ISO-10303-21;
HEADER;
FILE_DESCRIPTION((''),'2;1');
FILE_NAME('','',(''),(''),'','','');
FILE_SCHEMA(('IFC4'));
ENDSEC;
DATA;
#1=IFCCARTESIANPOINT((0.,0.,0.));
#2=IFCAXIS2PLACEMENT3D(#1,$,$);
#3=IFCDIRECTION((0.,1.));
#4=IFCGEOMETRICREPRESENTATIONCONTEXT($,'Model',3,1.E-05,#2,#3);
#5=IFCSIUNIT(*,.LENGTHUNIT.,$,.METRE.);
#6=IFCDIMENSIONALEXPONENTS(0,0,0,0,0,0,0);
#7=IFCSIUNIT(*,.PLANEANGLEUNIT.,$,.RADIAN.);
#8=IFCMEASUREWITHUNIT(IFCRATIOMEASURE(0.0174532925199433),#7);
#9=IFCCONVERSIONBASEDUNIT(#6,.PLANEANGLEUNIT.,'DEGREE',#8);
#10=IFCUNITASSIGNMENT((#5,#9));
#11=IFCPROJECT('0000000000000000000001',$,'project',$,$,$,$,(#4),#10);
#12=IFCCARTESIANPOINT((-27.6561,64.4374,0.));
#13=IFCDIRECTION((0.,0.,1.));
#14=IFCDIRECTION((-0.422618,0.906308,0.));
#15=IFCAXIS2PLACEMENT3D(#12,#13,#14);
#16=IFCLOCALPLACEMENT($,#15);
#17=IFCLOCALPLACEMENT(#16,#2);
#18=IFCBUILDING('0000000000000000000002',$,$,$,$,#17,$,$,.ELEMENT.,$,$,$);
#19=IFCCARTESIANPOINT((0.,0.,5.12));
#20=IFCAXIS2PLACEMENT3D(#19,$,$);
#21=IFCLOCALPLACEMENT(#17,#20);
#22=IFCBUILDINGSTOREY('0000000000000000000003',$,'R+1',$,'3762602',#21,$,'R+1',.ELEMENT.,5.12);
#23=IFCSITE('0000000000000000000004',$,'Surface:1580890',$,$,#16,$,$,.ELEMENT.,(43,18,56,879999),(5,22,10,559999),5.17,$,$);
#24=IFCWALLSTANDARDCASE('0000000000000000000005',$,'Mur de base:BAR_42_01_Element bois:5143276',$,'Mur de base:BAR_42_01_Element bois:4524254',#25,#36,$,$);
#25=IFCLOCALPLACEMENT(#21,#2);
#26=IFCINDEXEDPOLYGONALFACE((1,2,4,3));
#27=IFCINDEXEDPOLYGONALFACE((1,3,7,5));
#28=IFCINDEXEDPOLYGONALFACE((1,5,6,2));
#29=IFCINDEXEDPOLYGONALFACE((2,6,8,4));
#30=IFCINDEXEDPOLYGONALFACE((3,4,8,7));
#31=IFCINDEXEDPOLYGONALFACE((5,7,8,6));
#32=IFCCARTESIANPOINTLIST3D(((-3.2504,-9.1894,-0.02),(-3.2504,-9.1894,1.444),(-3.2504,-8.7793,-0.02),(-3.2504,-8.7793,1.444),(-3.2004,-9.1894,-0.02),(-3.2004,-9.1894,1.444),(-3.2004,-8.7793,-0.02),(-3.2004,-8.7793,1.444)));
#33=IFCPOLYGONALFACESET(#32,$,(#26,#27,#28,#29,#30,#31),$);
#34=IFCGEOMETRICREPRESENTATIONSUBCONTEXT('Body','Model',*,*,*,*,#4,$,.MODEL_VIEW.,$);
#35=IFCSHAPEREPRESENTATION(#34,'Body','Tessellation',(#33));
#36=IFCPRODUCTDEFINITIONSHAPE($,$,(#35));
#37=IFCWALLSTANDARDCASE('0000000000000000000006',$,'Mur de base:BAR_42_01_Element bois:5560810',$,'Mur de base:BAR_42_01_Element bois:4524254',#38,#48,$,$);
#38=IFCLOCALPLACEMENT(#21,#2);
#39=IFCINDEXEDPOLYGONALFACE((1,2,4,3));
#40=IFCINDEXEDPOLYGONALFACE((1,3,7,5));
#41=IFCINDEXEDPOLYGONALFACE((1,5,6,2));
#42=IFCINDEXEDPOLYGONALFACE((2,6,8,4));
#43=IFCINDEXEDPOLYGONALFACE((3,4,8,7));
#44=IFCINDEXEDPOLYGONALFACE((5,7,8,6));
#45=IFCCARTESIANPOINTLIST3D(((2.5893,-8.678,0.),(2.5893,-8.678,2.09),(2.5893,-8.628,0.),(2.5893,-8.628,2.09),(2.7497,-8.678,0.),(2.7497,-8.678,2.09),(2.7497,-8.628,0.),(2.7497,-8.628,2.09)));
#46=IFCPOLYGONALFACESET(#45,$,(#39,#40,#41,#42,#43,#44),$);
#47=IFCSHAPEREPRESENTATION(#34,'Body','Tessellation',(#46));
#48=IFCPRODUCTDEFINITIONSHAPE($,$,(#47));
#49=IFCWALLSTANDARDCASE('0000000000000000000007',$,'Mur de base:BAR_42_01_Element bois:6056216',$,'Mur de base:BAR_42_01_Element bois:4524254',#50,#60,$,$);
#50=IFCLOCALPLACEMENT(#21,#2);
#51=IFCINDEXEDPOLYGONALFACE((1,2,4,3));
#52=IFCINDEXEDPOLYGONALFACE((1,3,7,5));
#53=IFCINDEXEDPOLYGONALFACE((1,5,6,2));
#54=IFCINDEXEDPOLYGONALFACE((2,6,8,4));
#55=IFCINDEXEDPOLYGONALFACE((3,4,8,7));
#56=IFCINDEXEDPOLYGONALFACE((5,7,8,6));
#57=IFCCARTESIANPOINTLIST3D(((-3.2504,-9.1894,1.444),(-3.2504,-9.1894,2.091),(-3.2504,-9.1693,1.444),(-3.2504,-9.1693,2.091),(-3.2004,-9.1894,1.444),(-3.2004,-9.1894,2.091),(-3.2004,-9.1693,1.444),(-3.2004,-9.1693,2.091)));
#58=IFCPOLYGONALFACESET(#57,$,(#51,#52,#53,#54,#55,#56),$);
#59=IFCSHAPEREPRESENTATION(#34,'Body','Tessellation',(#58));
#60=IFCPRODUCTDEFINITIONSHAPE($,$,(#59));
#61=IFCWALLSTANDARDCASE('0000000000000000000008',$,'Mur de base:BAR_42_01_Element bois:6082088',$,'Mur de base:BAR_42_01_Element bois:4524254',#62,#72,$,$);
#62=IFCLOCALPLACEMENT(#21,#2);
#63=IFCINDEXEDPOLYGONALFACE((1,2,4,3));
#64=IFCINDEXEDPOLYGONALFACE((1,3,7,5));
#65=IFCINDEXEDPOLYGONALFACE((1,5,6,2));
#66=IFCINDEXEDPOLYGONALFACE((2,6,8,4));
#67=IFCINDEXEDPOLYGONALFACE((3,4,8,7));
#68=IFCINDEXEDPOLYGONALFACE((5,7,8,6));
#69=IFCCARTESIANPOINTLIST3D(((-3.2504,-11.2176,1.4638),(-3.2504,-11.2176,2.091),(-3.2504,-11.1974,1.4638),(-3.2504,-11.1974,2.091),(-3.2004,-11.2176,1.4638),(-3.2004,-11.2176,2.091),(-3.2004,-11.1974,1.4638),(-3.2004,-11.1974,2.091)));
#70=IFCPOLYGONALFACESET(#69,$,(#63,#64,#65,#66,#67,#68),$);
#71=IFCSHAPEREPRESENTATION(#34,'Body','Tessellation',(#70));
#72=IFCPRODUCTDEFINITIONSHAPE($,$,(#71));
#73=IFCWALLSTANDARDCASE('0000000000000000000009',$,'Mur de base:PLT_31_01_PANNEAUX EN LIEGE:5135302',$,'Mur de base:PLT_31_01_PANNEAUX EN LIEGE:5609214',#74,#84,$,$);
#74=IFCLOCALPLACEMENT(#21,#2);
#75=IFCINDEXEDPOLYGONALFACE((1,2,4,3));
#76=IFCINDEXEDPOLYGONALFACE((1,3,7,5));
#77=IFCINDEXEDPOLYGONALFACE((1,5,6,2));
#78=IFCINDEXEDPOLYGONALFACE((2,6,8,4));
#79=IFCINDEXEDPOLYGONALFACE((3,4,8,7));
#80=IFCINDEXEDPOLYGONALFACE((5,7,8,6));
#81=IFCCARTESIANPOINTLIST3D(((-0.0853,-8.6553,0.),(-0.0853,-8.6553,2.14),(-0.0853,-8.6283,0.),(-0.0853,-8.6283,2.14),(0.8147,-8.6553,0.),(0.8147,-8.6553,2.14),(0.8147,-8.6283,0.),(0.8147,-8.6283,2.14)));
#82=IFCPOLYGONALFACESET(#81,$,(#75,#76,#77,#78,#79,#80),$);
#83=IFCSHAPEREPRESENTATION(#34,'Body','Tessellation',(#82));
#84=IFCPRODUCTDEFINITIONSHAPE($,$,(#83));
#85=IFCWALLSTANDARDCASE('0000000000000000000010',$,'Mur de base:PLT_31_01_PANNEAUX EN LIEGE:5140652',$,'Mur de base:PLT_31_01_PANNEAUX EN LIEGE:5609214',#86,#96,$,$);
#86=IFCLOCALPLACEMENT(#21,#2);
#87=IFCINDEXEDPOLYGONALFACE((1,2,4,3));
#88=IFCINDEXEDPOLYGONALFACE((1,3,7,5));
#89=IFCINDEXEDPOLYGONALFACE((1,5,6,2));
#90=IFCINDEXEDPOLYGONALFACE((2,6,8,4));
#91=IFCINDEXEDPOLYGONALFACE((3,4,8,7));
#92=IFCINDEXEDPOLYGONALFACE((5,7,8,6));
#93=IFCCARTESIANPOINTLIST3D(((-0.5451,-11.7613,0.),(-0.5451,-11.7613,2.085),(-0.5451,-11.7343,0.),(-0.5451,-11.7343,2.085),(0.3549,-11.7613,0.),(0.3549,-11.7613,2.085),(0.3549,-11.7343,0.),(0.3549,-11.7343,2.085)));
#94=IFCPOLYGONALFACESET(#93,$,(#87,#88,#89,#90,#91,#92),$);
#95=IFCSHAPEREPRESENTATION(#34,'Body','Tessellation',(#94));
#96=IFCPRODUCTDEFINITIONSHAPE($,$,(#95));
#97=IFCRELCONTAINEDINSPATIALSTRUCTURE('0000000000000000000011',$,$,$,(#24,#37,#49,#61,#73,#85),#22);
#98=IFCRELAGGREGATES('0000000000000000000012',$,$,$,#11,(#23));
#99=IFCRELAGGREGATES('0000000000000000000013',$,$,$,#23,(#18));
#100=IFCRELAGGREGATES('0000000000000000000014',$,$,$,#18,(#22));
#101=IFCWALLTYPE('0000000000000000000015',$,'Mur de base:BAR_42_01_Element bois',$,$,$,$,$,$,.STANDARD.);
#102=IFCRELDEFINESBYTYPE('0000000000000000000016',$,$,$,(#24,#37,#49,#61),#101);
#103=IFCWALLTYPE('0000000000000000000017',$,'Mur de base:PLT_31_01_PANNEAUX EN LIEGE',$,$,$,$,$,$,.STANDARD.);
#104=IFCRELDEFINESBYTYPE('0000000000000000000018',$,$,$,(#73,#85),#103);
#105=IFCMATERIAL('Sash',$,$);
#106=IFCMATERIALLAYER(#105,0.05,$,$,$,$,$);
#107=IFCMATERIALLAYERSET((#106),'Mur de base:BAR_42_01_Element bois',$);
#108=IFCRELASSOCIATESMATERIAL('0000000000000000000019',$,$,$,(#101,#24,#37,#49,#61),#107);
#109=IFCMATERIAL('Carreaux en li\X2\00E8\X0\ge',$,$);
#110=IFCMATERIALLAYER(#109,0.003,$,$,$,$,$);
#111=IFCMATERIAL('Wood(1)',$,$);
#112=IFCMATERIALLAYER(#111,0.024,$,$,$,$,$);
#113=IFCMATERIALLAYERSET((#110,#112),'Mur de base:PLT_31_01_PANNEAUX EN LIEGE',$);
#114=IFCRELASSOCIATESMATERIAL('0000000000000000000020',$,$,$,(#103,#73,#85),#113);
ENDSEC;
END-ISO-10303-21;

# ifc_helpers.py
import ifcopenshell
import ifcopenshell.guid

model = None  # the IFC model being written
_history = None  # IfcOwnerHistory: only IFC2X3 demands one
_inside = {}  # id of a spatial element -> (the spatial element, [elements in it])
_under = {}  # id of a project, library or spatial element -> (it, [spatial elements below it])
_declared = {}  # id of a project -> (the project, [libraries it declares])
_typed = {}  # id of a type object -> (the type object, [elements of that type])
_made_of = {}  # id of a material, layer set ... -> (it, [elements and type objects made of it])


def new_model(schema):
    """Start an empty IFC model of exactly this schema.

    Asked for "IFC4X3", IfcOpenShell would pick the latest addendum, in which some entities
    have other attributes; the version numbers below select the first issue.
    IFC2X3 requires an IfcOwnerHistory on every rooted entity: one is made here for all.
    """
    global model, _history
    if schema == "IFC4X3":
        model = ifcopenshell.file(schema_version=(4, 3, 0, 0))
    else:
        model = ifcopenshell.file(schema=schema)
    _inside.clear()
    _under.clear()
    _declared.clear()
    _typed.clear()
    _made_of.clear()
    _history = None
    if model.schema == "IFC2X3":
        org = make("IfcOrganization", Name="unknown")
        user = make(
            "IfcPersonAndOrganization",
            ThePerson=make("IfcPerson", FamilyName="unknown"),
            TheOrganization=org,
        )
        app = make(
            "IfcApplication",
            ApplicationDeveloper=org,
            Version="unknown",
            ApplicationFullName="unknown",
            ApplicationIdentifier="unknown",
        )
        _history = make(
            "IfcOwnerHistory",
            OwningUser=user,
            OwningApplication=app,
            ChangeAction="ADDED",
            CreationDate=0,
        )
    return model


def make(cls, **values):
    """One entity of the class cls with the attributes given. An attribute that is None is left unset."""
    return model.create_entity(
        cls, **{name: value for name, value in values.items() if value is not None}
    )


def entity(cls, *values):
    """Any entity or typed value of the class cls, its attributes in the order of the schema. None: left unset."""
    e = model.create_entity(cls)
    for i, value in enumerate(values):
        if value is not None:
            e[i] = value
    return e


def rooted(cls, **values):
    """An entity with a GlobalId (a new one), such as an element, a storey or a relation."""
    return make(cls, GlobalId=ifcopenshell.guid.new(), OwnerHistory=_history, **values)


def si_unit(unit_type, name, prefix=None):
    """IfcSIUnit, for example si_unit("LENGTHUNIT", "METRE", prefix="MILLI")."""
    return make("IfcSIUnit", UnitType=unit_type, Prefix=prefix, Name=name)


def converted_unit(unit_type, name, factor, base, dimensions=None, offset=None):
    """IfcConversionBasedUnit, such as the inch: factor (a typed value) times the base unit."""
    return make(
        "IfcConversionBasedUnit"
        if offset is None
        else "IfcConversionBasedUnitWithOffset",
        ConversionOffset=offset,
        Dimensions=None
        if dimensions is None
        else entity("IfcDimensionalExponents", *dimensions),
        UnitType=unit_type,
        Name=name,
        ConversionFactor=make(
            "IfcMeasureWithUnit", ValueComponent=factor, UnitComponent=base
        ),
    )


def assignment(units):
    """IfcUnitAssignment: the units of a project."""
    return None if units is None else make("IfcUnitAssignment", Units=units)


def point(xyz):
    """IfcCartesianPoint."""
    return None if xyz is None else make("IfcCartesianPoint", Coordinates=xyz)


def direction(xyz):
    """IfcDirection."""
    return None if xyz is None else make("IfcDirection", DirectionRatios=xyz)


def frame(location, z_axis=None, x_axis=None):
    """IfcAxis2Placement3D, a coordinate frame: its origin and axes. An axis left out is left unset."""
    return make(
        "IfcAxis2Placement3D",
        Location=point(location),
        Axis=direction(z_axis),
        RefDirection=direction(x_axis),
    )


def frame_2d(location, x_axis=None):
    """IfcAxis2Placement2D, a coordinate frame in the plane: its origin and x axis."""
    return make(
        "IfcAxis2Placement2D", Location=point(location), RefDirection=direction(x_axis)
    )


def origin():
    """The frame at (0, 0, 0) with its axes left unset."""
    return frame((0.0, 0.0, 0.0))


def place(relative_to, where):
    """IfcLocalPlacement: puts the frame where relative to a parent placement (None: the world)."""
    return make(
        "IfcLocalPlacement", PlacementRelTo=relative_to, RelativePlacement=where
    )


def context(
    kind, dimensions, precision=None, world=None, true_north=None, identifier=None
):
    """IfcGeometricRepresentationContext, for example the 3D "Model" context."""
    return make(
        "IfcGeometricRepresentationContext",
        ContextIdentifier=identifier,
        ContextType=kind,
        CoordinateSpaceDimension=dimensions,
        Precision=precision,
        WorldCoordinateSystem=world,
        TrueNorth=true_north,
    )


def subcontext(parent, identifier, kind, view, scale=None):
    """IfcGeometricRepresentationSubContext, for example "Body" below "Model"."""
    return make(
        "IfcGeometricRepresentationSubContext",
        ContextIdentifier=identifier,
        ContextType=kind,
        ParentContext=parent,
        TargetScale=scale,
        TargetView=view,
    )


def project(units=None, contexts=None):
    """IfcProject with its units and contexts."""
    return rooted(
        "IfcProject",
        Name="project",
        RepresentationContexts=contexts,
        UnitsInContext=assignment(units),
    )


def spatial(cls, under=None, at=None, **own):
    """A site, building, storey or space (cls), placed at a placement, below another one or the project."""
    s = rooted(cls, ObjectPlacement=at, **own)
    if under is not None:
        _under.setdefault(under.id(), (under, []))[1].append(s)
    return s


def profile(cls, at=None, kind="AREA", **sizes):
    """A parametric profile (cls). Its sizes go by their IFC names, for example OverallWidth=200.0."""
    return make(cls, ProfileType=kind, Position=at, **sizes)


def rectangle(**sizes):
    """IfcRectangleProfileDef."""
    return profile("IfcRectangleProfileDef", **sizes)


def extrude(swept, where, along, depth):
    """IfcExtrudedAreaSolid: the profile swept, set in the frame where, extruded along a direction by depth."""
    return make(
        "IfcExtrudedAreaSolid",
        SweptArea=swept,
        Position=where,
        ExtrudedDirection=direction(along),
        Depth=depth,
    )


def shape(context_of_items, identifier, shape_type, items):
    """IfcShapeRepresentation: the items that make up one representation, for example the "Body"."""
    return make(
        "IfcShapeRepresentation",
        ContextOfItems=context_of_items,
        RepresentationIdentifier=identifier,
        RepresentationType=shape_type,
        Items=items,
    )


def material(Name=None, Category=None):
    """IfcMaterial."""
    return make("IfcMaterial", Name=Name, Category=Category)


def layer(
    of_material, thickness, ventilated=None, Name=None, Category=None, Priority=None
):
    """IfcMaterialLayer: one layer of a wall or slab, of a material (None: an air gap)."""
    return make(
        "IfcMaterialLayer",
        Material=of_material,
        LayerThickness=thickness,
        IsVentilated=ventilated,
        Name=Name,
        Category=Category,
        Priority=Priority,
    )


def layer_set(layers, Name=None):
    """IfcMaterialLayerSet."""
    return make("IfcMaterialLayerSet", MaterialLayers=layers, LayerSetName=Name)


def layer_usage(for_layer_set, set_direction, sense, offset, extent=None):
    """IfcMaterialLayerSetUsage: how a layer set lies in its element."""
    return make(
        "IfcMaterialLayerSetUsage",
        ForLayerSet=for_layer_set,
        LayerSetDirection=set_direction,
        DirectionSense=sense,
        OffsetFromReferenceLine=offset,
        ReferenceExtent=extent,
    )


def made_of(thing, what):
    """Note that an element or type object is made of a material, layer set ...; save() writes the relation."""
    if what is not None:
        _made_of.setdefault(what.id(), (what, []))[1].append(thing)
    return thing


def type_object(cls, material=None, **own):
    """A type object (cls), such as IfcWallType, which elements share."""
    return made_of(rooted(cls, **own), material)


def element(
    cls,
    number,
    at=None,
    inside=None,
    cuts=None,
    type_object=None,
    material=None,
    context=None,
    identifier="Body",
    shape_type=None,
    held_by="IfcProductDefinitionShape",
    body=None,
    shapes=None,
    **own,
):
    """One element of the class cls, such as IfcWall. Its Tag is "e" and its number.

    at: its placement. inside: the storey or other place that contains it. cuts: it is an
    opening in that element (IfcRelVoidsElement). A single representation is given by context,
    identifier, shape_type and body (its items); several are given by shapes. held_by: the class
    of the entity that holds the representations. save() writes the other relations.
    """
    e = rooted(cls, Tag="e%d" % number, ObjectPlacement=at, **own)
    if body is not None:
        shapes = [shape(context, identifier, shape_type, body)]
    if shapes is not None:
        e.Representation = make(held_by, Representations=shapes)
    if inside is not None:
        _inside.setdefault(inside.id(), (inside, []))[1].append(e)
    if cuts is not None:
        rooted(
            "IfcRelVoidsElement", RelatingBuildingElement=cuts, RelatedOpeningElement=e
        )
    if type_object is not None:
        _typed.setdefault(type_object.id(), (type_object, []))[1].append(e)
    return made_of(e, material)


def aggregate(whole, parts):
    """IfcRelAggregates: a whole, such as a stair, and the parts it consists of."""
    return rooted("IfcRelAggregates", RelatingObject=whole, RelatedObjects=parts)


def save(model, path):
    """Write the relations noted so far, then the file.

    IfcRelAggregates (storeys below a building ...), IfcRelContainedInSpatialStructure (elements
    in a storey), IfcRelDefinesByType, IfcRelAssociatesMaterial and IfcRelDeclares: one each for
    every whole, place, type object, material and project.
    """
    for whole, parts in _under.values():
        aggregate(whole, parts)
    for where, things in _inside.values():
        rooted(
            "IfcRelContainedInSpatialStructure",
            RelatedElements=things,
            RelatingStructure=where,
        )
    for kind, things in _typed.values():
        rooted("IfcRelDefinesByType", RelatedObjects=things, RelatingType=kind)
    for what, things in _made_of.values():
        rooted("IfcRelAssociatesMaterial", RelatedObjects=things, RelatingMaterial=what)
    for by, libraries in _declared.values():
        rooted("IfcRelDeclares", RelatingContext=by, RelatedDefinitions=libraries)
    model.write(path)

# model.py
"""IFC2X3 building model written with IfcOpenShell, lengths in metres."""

from ifc_helpers import new_model, entity, si_unit, converted_unit, direction, frame, frame_2d, origin, place, context, subcontext, project, spatial, rectangle, extrude, material, layer, layer_set, layer_usage, type_object, element, save


model = new_model("IFC2X3")

# Units and contexts
model_context = context("Model", 3, precision=1e-05, world=origin(), true_north=direction((0.0, 1.0)))
body_context = subcontext(model_context, "Body", "Model", "MODEL_VIEW")
ifc_project = project(units=[si_unit("LENGTHUNIT", "METRE"), converted_unit("PLANEANGLEUNIT", "DEGREE", entity("IfcRatioMeasure", 0.0174532925199433), si_unit("PLANEANGLEUNIT", "RADIAN"), dimensions=[0, 0, 0, 0, 0, 0, 0])], contexts=[model_context])

# Site, building, storey
site_placement = place(None, frame((-27.6561, 64.4374, 0.0), z_axis=(0.0, 0.0, 1.0), x_axis=(-0.422618, 0.906308, 0.0)))
site = spatial("IfcSite", under=ifc_project, at=site_placement, Name="Surface:1580890", CompositionType="ELEMENT", RefLatitude=(43, 18, 56, 879999), RefLongitude=(5, 22, 10, 559999), RefElevation=5.17)
building_placement = place(site_placement, origin())
building = spatial("IfcBuilding", under=site, at=building_placement, CompositionType="ELEMENT")
storey_placement = place(building_placement, frame((0.0, 0.0, 5.12)))
storey = spatial("IfcBuildingStorey", under=building, at=storey_placement, Name="R+1", ObjectType="3762602", LongName="R+1", CompositionType="ELEMENT", Elevation=5.12)

# Shared definitions
ifc_material_1 = material(Name="Sash")

# Shared definitions
ifc_layer_1 = layer(ifc_material_1, 0.05)
ifc_layer_set_1 = layer_set([ifc_layer_1], Name="Mur de base:BAR_42_01_Element bois")
wall_type_1 = type_object("IfcWallType", Name="Mur de base:BAR_42_01_Element bois", PredefinedType="STANDARD", material=ifc_layer_set_1)

# Walls
ifc_layer_usage_1 = layer_usage(ifc_layer_set_1, "AXIS2", "POSITIVE", -0.025)
wall_1_placement = place(storey_placement, frame((-3.2254, -8.7793, -0.02), z_axis=(0.0, 0.0, 1.0), x_axis=(0.0, -1.0, 0.0)))
element("IfcWallStandardCase", 1, at=wall_1_placement, inside=storey, type_object=wall_type_1, material=ifc_layer_usage_1, Name="Mur de base:BAR_42_01_Element bois:5143276", ObjectType="Mur de base:BAR_42_01_Element bois:4524254", context=body_context, shape_type="SweptSolid", body=[
    extrude(rectangle(XDim=0.4102, YDim=0.05, at=frame_2d((0.2051, 0.0), x_axis=(-1.0, 0.0))), origin(), (0.0, 0.0, 1.0), 1.464),
])
ifc_layer_usage_2 = layer_usage(ifc_layer_set_1, "AXIS2", "POSITIVE", -0.025)
wall_2_placement = place(storey_placement, frame((2.7497, -8.653, 0.0), z_axis=(0.0, 0.0, 1.0), x_axis=(-1.0, 0.0, 0.0)))
element("IfcWallStandardCase", 2, at=wall_2_placement, inside=storey, type_object=wall_type_1, material=ifc_layer_usage_2, Name="Mur de base:BAR_42_01_Element bois:5560810", ObjectType="Mur de base:BAR_42_01_Element bois:4524254", context=body_context, shape_type="SweptSolid", body=[
    extrude(rectangle(XDim=0.1603, YDim=0.05, at=frame_2d((0.0802, 0.0), x_axis=(-1.0, 0.0))), origin(), (0.0, 0.0, 1.0), 2.09),
])
ifc_layer_usage_3 = layer_usage(ifc_layer_set_1, "AXIS2", "POSITIVE", -0.025)
wall_3_placement = place(storey_placement, frame((-3.2254, -9.1693, 1.444), z_axis=(0.0, 0.0, 1.0), x_axis=(0.0, -1.0, 0.0)))
element("IfcWallStandardCase", 3, at=wall_3_placement, inside=storey, type_object=wall_type_1, material=ifc_layer_usage_3, Name="Mur de base:BAR_42_01_Element bois:6056216", ObjectType="Mur de base:BAR_42_01_Element bois:4524254", context=body_context, shape_type="SweptSolid", body=[
    extrude(rectangle(XDim=0.0202, YDim=0.05, at=frame_2d((0.0101, 0.0), x_axis=(-1.0, 0.0))), origin(), (0.0, 0.0, 1.0), 0.647),
])
ifc_layer_usage_4 = layer_usage(ifc_layer_set_1, "AXIS2", "NEGATIVE", 0.025)
wall_4_placement = place(storey_placement, frame((-3.2254, -11.2176, 1.4638), z_axis=(0.0, 0.0, 1.0), x_axis=(0.0, 1.0, 0.0)))
element("IfcWallStandardCase", 4, at=wall_4_placement, inside=storey, type_object=wall_type_1, material=ifc_layer_usage_4, Name="Mur de base:BAR_42_01_Element bois:6082088", ObjectType="Mur de base:BAR_42_01_Element bois:4524254", context=body_context, shape_type="SweptSolid", body=[
    extrude(rectangle(XDim=0.0202, YDim=0.05, at=frame_2d((0.0101, 0.0), x_axis=(-1.0, 0.0))), origin(), (0.0, 0.0, 1.0), 0.6272),
])
ifc_material_2 = material(Name="Carreaux en liège")
ifc_layer_2 = layer(ifc_material_2, 0.003)
ifc_material_3 = material(Name="Wood(1)")
ifc_layer_3 = layer(ifc_material_3, 0.024)
ifc_layer_set_2 = layer_set([ifc_layer_2, ifc_layer_3], Name="Mur de base:PLT_31_01_PANNEAUX EN LIEGE")
ifc_layer_usage_5 = layer_usage(ifc_layer_set_2, "AXIS2", "POSITIVE", -0.0135)
wall_type_2 = type_object("IfcWallType", Name="Mur de base:PLT_31_01_PANNEAUX EN LIEGE", PredefinedType="STANDARD", material=ifc_layer_set_2)
wall_5_placement = place(storey_placement, frame((0.8147, -8.6418, 0.0), z_axis=(0.0, 0.0, 1.0), x_axis=(-1.0, 0.0, 0.0)))
element("IfcWallStandardCase", 5, at=wall_5_placement, inside=storey, type_object=wall_type_2, material=ifc_layer_usage_5, Name="Mur de base:PLT_31_01_PANNEAUX EN LIEGE:5135302", ObjectType="Mur de base:PLT_31_01_PANNEAUX EN LIEGE:5609214", context=body_context, shape_type="SweptSolid", body=[
    extrude(rectangle(XDim=0.9, YDim=0.027, at=frame_2d((0.45, 0.0), x_axis=(-1.0, 0.0))), origin(), (0.0, 0.0, 1.0), 2.14),
])
ifc_layer_usage_6 = layer_usage(ifc_layer_set_2, "AXIS2", "NEGATIVE", 0.0135)
wall_6_placement = place(storey_placement, frame((0.3549, -11.7478, 0.0), z_axis=(0.0, 0.0, 1.0), x_axis=(-1.0, 0.0, 0.0)))
element("IfcWallStandardCase", 6, at=wall_6_placement, inside=storey, type_object=wall_type_2, material=ifc_layer_usage_6, Name="Mur de base:PLT_31_01_PANNEAUX EN LIEGE:5140652", ObjectType="Mur de base:PLT_31_01_PANNEAUX EN LIEGE:5609214", context=body_context, shape_type="SweptSolid", body=[
    extrude(rectangle(XDim=0.9, YDim=0.027, at=frame_2d((0.45, 0.0), x_axis=(-1.0, 0.0))), origin(), (0.0, 0.0, 1.0), 2.085),
])

save(model, "model.ifc")
